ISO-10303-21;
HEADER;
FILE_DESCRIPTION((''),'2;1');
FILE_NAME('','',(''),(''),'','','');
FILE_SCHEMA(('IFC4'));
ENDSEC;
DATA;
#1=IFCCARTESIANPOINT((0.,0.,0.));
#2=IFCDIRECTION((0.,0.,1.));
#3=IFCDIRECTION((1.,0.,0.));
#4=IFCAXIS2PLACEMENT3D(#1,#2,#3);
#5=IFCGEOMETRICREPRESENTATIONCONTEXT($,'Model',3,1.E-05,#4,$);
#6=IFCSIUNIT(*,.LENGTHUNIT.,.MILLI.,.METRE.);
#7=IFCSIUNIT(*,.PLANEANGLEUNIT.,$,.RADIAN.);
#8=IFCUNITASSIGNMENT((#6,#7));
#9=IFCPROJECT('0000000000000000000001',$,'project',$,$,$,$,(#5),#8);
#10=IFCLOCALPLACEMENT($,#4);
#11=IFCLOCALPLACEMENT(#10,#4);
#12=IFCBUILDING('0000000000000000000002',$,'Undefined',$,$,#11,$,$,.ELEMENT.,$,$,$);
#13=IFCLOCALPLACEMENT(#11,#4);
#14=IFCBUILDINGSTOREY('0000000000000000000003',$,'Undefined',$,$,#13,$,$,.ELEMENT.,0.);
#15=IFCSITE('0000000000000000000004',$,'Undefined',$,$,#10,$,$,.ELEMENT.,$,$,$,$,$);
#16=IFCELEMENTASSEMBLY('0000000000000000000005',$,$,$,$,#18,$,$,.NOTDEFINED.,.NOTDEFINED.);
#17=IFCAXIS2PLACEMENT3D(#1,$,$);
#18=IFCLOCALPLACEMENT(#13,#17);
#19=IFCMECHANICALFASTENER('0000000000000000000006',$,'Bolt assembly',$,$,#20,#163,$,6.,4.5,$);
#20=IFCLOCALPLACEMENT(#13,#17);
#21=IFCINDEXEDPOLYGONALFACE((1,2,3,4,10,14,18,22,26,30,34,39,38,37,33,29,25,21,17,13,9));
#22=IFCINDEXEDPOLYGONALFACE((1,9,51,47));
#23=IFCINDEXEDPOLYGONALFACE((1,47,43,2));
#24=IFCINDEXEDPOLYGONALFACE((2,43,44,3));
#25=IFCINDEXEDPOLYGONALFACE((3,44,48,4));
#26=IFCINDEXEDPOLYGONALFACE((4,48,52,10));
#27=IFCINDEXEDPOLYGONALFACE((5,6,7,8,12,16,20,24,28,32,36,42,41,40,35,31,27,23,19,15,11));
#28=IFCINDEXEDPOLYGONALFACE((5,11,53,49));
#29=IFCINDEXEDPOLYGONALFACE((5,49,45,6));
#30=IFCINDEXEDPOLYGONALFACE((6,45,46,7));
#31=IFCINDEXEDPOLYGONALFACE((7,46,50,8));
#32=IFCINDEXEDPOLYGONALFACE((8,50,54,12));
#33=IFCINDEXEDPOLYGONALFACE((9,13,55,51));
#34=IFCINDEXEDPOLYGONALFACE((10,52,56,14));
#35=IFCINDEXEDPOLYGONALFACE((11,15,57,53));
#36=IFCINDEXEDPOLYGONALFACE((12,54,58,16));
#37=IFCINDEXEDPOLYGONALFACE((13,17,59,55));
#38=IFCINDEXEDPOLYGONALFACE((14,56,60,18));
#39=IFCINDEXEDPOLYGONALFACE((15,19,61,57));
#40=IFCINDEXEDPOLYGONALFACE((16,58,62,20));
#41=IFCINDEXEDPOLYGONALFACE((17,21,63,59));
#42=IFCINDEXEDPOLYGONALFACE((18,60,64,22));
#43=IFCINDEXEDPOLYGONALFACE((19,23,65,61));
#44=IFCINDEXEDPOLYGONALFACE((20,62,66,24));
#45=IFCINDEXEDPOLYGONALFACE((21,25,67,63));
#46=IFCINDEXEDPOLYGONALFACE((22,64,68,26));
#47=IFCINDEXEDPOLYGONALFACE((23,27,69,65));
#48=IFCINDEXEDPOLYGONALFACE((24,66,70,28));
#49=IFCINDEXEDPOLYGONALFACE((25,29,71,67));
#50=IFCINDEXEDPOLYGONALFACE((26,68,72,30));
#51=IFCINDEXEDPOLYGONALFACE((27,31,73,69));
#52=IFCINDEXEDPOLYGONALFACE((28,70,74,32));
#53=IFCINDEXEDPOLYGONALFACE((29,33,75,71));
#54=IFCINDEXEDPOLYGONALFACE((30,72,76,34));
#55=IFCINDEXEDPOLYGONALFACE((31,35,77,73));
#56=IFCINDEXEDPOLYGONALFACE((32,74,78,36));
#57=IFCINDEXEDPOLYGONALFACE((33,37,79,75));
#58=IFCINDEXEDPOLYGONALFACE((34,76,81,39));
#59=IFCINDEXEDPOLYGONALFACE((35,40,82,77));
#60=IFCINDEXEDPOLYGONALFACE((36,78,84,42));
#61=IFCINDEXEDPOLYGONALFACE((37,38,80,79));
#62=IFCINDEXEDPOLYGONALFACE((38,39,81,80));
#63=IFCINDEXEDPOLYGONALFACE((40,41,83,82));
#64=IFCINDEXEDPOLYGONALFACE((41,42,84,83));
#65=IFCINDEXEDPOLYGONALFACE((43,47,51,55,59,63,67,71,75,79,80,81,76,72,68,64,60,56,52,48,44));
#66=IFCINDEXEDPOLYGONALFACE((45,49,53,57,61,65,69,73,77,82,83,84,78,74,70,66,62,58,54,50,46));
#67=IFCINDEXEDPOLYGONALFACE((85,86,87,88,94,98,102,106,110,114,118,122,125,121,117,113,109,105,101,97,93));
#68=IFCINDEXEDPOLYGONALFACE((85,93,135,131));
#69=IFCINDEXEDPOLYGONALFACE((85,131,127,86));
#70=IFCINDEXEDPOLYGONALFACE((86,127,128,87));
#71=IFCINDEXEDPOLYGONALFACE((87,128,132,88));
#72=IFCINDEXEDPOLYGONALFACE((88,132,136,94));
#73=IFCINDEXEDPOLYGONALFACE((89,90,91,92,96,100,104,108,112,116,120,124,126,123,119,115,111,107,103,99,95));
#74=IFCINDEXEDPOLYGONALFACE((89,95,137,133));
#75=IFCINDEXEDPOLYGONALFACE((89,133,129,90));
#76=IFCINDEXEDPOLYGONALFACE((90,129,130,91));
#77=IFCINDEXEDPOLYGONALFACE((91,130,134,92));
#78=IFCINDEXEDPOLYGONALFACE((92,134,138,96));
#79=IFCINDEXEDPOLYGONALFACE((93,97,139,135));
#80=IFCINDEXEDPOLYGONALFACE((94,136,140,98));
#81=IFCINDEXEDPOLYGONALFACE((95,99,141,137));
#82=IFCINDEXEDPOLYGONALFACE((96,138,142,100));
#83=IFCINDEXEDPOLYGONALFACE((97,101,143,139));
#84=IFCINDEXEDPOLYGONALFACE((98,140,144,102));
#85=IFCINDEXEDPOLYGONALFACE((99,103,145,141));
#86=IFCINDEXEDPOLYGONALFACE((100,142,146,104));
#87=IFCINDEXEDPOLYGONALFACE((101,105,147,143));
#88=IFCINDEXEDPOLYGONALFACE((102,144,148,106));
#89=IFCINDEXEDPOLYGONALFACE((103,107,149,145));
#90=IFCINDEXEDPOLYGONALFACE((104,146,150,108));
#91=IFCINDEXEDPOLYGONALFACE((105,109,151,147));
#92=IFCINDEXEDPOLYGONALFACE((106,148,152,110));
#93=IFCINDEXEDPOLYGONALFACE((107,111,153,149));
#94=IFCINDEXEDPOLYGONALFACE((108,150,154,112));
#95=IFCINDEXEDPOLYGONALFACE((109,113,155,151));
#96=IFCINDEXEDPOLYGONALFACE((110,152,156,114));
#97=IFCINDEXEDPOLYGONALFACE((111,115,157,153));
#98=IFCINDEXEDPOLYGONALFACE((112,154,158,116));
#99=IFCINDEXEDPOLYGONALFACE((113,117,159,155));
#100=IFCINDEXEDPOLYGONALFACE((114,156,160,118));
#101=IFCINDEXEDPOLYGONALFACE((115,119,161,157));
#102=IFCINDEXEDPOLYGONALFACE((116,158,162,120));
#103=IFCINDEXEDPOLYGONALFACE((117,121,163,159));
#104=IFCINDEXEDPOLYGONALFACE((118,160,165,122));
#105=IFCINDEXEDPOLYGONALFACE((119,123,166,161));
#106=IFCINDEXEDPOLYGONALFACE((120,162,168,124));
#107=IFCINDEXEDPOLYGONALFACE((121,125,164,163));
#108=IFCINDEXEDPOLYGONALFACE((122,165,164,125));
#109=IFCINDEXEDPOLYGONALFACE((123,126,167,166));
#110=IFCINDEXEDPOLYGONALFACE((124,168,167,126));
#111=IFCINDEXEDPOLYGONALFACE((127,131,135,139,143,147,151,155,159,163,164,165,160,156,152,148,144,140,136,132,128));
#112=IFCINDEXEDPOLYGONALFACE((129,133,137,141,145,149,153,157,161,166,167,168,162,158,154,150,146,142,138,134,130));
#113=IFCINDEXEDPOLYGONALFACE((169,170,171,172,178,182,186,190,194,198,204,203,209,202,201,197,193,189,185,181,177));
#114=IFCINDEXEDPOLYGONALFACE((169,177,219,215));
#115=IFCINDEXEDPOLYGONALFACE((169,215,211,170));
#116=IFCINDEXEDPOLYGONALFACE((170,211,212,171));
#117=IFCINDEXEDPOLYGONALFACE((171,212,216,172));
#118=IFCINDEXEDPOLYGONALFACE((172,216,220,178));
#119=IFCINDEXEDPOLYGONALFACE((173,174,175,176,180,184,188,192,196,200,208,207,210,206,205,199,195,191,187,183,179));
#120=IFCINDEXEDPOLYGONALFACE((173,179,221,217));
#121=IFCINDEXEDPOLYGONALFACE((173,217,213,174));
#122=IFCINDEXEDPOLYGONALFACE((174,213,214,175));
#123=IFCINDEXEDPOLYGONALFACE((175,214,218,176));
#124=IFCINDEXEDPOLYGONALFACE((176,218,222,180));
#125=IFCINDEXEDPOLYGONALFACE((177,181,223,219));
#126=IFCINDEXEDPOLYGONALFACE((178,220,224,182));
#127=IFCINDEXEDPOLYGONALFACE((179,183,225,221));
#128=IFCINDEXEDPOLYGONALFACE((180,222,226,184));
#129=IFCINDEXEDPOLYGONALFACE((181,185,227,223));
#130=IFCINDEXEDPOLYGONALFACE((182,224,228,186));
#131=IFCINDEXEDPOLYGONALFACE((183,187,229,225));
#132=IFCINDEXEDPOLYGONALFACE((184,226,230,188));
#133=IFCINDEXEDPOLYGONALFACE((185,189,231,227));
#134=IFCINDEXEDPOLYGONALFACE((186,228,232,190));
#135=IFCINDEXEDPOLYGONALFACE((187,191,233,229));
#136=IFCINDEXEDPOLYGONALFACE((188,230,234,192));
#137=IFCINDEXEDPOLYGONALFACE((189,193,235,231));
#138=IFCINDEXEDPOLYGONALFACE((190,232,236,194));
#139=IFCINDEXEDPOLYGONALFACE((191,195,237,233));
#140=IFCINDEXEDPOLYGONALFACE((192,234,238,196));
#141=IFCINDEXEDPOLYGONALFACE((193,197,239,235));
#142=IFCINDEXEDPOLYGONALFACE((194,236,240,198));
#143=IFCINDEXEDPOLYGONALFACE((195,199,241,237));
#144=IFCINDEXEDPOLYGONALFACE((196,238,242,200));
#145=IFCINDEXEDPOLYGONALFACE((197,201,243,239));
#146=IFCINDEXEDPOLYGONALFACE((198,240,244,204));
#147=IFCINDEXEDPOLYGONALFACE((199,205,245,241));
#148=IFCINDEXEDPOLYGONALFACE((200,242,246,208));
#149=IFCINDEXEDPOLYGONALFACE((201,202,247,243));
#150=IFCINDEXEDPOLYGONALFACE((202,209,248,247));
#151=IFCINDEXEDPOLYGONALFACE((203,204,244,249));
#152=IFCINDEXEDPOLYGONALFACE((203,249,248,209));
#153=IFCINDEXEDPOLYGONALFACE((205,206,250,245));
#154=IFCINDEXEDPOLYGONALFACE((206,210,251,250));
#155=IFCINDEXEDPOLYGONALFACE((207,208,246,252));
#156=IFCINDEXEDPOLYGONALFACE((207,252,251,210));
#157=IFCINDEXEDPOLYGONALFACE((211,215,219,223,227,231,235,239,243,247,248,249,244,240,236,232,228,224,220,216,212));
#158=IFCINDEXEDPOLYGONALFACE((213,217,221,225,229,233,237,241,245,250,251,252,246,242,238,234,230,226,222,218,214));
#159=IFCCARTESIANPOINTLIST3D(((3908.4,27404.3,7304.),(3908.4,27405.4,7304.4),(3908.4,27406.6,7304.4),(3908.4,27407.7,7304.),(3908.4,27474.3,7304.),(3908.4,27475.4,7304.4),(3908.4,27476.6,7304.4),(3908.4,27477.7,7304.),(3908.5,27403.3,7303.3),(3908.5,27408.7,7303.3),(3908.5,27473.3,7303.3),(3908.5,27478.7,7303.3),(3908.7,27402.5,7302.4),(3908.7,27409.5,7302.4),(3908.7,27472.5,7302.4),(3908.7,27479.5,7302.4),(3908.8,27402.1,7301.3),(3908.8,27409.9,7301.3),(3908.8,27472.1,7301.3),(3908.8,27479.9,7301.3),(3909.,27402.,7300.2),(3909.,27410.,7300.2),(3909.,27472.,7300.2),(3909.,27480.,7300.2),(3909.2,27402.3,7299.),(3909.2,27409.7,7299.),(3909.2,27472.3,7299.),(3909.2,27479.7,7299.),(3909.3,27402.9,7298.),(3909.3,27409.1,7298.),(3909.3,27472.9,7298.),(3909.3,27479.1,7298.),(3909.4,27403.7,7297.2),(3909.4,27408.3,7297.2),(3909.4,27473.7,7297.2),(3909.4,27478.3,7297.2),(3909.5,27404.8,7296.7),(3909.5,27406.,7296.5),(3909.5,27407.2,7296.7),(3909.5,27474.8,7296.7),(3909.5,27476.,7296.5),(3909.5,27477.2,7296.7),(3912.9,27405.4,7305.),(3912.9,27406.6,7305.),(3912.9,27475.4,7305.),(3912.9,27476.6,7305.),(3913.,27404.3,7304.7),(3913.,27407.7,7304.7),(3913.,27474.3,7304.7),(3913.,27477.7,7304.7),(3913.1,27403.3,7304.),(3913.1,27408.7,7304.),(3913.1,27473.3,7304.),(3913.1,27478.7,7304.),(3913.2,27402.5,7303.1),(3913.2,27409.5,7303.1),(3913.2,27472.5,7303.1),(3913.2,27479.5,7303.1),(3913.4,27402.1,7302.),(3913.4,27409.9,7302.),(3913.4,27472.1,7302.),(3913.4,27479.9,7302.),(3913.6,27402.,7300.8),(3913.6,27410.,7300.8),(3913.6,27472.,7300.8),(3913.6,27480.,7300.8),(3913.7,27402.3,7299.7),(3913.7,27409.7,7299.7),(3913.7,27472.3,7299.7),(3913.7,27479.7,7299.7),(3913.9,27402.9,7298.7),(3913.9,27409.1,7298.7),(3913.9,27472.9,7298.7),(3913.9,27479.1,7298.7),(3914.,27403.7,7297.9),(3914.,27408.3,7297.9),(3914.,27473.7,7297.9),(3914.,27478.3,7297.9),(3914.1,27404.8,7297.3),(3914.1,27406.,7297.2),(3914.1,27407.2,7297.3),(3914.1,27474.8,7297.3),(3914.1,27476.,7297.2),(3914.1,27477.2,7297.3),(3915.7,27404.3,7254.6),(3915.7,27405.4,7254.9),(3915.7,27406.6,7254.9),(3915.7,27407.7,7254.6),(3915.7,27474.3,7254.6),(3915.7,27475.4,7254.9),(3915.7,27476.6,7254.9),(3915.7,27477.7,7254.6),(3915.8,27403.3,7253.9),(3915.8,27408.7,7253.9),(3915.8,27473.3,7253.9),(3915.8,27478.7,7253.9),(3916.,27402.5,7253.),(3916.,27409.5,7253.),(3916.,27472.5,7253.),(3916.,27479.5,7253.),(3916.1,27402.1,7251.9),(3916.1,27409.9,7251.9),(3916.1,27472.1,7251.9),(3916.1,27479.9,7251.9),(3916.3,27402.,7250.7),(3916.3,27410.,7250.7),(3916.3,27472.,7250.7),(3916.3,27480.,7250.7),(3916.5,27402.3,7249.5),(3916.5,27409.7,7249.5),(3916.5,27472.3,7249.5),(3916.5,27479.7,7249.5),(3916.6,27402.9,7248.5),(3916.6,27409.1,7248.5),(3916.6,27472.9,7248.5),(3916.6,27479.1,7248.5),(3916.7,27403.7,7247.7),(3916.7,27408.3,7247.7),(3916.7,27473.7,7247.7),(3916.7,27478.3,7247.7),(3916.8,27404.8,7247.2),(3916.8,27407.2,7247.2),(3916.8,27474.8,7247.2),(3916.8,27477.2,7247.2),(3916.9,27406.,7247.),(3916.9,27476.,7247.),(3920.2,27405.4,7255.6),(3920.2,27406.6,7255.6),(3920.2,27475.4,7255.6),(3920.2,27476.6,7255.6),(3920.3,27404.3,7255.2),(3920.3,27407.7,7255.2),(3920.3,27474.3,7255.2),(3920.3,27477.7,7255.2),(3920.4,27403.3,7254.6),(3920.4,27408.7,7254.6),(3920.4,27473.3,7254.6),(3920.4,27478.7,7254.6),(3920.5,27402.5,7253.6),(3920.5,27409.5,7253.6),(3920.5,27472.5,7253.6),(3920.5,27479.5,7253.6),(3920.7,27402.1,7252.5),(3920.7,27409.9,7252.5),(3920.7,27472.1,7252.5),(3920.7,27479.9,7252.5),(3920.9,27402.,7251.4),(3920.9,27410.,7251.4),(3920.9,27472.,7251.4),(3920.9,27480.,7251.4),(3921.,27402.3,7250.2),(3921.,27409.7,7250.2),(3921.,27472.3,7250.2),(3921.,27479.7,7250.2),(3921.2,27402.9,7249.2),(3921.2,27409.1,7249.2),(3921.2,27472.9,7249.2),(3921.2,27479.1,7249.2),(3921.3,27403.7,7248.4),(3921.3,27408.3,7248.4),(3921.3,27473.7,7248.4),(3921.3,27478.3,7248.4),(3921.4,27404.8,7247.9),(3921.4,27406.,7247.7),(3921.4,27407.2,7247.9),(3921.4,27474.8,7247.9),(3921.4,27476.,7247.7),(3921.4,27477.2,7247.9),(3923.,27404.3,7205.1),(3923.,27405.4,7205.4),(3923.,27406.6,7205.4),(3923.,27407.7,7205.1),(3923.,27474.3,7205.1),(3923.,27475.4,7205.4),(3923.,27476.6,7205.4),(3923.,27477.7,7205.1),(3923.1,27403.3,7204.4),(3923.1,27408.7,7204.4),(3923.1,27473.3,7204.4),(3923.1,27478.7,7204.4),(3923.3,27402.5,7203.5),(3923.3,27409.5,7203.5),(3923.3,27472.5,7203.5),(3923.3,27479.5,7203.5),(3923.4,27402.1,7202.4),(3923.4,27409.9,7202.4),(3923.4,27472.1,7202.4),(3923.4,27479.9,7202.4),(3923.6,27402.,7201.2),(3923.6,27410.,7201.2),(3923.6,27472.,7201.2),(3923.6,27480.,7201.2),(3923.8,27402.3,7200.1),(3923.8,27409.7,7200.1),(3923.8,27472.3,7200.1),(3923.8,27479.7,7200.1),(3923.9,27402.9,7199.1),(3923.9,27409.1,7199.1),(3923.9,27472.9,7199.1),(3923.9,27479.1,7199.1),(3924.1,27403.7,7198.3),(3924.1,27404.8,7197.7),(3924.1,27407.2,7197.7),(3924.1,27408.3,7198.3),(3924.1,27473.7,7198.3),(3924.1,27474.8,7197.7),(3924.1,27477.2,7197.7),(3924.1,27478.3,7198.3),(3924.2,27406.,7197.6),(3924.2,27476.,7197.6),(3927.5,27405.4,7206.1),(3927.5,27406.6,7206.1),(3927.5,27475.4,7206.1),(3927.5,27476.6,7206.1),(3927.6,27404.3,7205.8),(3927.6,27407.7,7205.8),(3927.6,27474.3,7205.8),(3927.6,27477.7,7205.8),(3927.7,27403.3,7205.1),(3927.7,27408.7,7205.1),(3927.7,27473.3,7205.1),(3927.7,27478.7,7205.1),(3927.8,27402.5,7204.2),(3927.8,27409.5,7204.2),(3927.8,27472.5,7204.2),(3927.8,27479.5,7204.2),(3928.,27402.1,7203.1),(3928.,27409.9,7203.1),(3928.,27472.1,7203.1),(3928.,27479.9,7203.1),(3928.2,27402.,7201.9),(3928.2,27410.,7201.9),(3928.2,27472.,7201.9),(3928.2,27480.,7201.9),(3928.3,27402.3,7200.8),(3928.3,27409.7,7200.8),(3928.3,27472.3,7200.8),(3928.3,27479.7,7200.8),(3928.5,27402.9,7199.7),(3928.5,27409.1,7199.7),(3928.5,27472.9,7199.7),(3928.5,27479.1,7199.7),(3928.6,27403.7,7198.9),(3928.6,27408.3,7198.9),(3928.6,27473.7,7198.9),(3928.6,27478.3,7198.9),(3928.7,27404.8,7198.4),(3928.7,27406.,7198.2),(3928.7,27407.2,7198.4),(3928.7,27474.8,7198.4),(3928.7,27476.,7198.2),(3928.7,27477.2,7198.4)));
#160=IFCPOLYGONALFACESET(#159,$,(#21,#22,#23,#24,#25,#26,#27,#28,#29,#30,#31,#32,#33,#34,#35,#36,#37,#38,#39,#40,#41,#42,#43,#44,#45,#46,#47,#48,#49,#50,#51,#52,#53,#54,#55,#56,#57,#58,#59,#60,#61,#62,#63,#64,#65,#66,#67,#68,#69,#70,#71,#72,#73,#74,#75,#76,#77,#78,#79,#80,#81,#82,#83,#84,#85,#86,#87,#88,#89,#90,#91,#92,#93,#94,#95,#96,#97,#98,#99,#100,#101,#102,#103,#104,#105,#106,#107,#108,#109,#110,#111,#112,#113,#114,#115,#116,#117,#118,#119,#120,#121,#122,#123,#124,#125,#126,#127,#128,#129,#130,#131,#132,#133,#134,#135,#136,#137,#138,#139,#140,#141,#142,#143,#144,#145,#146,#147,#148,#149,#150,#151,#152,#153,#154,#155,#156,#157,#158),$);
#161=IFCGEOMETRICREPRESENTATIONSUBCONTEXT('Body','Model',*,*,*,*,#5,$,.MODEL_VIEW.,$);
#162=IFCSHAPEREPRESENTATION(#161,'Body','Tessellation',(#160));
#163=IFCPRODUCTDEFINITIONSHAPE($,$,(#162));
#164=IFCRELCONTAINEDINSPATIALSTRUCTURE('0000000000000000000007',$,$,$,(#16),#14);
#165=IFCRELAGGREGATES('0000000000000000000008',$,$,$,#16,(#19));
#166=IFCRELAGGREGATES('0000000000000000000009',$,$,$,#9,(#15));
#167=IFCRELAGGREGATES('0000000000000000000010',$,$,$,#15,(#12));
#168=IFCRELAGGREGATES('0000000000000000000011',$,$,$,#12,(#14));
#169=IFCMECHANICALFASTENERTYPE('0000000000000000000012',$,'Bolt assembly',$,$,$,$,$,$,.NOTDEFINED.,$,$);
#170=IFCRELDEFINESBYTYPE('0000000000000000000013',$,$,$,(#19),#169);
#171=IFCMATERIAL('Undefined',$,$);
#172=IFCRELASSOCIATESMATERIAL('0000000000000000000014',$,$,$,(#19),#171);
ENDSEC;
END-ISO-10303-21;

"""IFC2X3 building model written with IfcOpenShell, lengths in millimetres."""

from ifc_helpers import new_model, si_unit, frame, origin_with_axes, origin_2d_with_axis, place, context, subcontext, project, spatial, circle, extrude, source, transform, mapped, material, type_object, element, aggregate, save


model = new_model("IFC2X3")

# Units and contexts
model_context = context("Model", 3, precision=1e-05, world=origin_with_axes())
body_context = subcontext(model_context, "Body", "Model", "MODEL_VIEW")
ifc_project = project(units=[si_unit("LENGTHUNIT", "METRE", prefix="MILLI"), si_unit("PLANEANGLEUNIT", "RADIAN")], contexts=[model_context])

# Site, building, storey
site_placement = place(None, origin_with_axes())
site = spatial("IfcSite", under=ifc_project, at=site_placement, Name="Undefined", CompositionType="ELEMENT")
building_placement = place(site_placement, origin_with_axes())
building = spatial("IfcBuilding", under=site, at=building_placement, Name="Undefined", CompositionType="ELEMENT")
storey_placement = place(building_placement, origin_with_axes())
storey = spatial("IfcBuildingStorey", under=building, at=storey_placement, Name="Undefined", CompositionType="ELEMENT", Elevation=0.0)

# Element assembly
assembly_1_placement = place(storey_placement, origin_with_axes())
assembly_1 = element("IfcElementAssembly", 1, at=assembly_1_placement, inside=storey, AssemblyPlace="NOTDEFINED", PredefinedType="NOTDEFINED")

# Mechanical fastener
ifc_material_1 = material(Name="Undefined")
mechanical_fastener_type = type_object("IfcMechanicalFastenerType", Name="Bolt assembly")
shared_shape_1 = source(origin_with_axes(), body_context, "Body", "SweptSolid", [
    extrude(circle(Radius=4.0, at=origin_2d_with_axis()), frame((0.0, 0.0, 0.0), z_axis=(0.0, 1.0, 0.0), x_axis=(1.0, 0.0, 0.0)), (0.0, 0.0, 1.0), 4.6),
])
mechanical_fastener_1_placement = place(assembly_1_placement, frame((3909.0, 27441.0, 7300.4), z_axis=(0.0, -1.0, 0.0), x_axis=(0.146203, 0.0, -0.989255)))
mechanical_fastener_1 = element("IfcMechanicalFastener", 2, at=mechanical_fastener_1_placement, type_object=mechanical_fastener_type, material=ifc_material_1, Name="Bolt assembly", NominalDiameter=6.0, NominalLength=4.5, context=body_context, shape_type="MappedRepresentation", body=[
    mapped(shared_shape_1, transform((0.0, 0.0, -35.0))),
    mapped(shared_shape_1, transform((50.0, 0.0, -35.0))),
    mapped(shared_shape_1, transform((100.0, 0.0, -35.0))),
    mapped(shared_shape_1, transform((0.0, 0.0, 35.0))),
    mapped(shared_shape_1, transform((50.0, 0.0, 35.0))),
    mapped(shared_shape_1, transform((100.0, 0.0, 35.0))),
])

aggregate(assembly_1, [mechanical_fastener_1])

save(model, "model.ifc")
